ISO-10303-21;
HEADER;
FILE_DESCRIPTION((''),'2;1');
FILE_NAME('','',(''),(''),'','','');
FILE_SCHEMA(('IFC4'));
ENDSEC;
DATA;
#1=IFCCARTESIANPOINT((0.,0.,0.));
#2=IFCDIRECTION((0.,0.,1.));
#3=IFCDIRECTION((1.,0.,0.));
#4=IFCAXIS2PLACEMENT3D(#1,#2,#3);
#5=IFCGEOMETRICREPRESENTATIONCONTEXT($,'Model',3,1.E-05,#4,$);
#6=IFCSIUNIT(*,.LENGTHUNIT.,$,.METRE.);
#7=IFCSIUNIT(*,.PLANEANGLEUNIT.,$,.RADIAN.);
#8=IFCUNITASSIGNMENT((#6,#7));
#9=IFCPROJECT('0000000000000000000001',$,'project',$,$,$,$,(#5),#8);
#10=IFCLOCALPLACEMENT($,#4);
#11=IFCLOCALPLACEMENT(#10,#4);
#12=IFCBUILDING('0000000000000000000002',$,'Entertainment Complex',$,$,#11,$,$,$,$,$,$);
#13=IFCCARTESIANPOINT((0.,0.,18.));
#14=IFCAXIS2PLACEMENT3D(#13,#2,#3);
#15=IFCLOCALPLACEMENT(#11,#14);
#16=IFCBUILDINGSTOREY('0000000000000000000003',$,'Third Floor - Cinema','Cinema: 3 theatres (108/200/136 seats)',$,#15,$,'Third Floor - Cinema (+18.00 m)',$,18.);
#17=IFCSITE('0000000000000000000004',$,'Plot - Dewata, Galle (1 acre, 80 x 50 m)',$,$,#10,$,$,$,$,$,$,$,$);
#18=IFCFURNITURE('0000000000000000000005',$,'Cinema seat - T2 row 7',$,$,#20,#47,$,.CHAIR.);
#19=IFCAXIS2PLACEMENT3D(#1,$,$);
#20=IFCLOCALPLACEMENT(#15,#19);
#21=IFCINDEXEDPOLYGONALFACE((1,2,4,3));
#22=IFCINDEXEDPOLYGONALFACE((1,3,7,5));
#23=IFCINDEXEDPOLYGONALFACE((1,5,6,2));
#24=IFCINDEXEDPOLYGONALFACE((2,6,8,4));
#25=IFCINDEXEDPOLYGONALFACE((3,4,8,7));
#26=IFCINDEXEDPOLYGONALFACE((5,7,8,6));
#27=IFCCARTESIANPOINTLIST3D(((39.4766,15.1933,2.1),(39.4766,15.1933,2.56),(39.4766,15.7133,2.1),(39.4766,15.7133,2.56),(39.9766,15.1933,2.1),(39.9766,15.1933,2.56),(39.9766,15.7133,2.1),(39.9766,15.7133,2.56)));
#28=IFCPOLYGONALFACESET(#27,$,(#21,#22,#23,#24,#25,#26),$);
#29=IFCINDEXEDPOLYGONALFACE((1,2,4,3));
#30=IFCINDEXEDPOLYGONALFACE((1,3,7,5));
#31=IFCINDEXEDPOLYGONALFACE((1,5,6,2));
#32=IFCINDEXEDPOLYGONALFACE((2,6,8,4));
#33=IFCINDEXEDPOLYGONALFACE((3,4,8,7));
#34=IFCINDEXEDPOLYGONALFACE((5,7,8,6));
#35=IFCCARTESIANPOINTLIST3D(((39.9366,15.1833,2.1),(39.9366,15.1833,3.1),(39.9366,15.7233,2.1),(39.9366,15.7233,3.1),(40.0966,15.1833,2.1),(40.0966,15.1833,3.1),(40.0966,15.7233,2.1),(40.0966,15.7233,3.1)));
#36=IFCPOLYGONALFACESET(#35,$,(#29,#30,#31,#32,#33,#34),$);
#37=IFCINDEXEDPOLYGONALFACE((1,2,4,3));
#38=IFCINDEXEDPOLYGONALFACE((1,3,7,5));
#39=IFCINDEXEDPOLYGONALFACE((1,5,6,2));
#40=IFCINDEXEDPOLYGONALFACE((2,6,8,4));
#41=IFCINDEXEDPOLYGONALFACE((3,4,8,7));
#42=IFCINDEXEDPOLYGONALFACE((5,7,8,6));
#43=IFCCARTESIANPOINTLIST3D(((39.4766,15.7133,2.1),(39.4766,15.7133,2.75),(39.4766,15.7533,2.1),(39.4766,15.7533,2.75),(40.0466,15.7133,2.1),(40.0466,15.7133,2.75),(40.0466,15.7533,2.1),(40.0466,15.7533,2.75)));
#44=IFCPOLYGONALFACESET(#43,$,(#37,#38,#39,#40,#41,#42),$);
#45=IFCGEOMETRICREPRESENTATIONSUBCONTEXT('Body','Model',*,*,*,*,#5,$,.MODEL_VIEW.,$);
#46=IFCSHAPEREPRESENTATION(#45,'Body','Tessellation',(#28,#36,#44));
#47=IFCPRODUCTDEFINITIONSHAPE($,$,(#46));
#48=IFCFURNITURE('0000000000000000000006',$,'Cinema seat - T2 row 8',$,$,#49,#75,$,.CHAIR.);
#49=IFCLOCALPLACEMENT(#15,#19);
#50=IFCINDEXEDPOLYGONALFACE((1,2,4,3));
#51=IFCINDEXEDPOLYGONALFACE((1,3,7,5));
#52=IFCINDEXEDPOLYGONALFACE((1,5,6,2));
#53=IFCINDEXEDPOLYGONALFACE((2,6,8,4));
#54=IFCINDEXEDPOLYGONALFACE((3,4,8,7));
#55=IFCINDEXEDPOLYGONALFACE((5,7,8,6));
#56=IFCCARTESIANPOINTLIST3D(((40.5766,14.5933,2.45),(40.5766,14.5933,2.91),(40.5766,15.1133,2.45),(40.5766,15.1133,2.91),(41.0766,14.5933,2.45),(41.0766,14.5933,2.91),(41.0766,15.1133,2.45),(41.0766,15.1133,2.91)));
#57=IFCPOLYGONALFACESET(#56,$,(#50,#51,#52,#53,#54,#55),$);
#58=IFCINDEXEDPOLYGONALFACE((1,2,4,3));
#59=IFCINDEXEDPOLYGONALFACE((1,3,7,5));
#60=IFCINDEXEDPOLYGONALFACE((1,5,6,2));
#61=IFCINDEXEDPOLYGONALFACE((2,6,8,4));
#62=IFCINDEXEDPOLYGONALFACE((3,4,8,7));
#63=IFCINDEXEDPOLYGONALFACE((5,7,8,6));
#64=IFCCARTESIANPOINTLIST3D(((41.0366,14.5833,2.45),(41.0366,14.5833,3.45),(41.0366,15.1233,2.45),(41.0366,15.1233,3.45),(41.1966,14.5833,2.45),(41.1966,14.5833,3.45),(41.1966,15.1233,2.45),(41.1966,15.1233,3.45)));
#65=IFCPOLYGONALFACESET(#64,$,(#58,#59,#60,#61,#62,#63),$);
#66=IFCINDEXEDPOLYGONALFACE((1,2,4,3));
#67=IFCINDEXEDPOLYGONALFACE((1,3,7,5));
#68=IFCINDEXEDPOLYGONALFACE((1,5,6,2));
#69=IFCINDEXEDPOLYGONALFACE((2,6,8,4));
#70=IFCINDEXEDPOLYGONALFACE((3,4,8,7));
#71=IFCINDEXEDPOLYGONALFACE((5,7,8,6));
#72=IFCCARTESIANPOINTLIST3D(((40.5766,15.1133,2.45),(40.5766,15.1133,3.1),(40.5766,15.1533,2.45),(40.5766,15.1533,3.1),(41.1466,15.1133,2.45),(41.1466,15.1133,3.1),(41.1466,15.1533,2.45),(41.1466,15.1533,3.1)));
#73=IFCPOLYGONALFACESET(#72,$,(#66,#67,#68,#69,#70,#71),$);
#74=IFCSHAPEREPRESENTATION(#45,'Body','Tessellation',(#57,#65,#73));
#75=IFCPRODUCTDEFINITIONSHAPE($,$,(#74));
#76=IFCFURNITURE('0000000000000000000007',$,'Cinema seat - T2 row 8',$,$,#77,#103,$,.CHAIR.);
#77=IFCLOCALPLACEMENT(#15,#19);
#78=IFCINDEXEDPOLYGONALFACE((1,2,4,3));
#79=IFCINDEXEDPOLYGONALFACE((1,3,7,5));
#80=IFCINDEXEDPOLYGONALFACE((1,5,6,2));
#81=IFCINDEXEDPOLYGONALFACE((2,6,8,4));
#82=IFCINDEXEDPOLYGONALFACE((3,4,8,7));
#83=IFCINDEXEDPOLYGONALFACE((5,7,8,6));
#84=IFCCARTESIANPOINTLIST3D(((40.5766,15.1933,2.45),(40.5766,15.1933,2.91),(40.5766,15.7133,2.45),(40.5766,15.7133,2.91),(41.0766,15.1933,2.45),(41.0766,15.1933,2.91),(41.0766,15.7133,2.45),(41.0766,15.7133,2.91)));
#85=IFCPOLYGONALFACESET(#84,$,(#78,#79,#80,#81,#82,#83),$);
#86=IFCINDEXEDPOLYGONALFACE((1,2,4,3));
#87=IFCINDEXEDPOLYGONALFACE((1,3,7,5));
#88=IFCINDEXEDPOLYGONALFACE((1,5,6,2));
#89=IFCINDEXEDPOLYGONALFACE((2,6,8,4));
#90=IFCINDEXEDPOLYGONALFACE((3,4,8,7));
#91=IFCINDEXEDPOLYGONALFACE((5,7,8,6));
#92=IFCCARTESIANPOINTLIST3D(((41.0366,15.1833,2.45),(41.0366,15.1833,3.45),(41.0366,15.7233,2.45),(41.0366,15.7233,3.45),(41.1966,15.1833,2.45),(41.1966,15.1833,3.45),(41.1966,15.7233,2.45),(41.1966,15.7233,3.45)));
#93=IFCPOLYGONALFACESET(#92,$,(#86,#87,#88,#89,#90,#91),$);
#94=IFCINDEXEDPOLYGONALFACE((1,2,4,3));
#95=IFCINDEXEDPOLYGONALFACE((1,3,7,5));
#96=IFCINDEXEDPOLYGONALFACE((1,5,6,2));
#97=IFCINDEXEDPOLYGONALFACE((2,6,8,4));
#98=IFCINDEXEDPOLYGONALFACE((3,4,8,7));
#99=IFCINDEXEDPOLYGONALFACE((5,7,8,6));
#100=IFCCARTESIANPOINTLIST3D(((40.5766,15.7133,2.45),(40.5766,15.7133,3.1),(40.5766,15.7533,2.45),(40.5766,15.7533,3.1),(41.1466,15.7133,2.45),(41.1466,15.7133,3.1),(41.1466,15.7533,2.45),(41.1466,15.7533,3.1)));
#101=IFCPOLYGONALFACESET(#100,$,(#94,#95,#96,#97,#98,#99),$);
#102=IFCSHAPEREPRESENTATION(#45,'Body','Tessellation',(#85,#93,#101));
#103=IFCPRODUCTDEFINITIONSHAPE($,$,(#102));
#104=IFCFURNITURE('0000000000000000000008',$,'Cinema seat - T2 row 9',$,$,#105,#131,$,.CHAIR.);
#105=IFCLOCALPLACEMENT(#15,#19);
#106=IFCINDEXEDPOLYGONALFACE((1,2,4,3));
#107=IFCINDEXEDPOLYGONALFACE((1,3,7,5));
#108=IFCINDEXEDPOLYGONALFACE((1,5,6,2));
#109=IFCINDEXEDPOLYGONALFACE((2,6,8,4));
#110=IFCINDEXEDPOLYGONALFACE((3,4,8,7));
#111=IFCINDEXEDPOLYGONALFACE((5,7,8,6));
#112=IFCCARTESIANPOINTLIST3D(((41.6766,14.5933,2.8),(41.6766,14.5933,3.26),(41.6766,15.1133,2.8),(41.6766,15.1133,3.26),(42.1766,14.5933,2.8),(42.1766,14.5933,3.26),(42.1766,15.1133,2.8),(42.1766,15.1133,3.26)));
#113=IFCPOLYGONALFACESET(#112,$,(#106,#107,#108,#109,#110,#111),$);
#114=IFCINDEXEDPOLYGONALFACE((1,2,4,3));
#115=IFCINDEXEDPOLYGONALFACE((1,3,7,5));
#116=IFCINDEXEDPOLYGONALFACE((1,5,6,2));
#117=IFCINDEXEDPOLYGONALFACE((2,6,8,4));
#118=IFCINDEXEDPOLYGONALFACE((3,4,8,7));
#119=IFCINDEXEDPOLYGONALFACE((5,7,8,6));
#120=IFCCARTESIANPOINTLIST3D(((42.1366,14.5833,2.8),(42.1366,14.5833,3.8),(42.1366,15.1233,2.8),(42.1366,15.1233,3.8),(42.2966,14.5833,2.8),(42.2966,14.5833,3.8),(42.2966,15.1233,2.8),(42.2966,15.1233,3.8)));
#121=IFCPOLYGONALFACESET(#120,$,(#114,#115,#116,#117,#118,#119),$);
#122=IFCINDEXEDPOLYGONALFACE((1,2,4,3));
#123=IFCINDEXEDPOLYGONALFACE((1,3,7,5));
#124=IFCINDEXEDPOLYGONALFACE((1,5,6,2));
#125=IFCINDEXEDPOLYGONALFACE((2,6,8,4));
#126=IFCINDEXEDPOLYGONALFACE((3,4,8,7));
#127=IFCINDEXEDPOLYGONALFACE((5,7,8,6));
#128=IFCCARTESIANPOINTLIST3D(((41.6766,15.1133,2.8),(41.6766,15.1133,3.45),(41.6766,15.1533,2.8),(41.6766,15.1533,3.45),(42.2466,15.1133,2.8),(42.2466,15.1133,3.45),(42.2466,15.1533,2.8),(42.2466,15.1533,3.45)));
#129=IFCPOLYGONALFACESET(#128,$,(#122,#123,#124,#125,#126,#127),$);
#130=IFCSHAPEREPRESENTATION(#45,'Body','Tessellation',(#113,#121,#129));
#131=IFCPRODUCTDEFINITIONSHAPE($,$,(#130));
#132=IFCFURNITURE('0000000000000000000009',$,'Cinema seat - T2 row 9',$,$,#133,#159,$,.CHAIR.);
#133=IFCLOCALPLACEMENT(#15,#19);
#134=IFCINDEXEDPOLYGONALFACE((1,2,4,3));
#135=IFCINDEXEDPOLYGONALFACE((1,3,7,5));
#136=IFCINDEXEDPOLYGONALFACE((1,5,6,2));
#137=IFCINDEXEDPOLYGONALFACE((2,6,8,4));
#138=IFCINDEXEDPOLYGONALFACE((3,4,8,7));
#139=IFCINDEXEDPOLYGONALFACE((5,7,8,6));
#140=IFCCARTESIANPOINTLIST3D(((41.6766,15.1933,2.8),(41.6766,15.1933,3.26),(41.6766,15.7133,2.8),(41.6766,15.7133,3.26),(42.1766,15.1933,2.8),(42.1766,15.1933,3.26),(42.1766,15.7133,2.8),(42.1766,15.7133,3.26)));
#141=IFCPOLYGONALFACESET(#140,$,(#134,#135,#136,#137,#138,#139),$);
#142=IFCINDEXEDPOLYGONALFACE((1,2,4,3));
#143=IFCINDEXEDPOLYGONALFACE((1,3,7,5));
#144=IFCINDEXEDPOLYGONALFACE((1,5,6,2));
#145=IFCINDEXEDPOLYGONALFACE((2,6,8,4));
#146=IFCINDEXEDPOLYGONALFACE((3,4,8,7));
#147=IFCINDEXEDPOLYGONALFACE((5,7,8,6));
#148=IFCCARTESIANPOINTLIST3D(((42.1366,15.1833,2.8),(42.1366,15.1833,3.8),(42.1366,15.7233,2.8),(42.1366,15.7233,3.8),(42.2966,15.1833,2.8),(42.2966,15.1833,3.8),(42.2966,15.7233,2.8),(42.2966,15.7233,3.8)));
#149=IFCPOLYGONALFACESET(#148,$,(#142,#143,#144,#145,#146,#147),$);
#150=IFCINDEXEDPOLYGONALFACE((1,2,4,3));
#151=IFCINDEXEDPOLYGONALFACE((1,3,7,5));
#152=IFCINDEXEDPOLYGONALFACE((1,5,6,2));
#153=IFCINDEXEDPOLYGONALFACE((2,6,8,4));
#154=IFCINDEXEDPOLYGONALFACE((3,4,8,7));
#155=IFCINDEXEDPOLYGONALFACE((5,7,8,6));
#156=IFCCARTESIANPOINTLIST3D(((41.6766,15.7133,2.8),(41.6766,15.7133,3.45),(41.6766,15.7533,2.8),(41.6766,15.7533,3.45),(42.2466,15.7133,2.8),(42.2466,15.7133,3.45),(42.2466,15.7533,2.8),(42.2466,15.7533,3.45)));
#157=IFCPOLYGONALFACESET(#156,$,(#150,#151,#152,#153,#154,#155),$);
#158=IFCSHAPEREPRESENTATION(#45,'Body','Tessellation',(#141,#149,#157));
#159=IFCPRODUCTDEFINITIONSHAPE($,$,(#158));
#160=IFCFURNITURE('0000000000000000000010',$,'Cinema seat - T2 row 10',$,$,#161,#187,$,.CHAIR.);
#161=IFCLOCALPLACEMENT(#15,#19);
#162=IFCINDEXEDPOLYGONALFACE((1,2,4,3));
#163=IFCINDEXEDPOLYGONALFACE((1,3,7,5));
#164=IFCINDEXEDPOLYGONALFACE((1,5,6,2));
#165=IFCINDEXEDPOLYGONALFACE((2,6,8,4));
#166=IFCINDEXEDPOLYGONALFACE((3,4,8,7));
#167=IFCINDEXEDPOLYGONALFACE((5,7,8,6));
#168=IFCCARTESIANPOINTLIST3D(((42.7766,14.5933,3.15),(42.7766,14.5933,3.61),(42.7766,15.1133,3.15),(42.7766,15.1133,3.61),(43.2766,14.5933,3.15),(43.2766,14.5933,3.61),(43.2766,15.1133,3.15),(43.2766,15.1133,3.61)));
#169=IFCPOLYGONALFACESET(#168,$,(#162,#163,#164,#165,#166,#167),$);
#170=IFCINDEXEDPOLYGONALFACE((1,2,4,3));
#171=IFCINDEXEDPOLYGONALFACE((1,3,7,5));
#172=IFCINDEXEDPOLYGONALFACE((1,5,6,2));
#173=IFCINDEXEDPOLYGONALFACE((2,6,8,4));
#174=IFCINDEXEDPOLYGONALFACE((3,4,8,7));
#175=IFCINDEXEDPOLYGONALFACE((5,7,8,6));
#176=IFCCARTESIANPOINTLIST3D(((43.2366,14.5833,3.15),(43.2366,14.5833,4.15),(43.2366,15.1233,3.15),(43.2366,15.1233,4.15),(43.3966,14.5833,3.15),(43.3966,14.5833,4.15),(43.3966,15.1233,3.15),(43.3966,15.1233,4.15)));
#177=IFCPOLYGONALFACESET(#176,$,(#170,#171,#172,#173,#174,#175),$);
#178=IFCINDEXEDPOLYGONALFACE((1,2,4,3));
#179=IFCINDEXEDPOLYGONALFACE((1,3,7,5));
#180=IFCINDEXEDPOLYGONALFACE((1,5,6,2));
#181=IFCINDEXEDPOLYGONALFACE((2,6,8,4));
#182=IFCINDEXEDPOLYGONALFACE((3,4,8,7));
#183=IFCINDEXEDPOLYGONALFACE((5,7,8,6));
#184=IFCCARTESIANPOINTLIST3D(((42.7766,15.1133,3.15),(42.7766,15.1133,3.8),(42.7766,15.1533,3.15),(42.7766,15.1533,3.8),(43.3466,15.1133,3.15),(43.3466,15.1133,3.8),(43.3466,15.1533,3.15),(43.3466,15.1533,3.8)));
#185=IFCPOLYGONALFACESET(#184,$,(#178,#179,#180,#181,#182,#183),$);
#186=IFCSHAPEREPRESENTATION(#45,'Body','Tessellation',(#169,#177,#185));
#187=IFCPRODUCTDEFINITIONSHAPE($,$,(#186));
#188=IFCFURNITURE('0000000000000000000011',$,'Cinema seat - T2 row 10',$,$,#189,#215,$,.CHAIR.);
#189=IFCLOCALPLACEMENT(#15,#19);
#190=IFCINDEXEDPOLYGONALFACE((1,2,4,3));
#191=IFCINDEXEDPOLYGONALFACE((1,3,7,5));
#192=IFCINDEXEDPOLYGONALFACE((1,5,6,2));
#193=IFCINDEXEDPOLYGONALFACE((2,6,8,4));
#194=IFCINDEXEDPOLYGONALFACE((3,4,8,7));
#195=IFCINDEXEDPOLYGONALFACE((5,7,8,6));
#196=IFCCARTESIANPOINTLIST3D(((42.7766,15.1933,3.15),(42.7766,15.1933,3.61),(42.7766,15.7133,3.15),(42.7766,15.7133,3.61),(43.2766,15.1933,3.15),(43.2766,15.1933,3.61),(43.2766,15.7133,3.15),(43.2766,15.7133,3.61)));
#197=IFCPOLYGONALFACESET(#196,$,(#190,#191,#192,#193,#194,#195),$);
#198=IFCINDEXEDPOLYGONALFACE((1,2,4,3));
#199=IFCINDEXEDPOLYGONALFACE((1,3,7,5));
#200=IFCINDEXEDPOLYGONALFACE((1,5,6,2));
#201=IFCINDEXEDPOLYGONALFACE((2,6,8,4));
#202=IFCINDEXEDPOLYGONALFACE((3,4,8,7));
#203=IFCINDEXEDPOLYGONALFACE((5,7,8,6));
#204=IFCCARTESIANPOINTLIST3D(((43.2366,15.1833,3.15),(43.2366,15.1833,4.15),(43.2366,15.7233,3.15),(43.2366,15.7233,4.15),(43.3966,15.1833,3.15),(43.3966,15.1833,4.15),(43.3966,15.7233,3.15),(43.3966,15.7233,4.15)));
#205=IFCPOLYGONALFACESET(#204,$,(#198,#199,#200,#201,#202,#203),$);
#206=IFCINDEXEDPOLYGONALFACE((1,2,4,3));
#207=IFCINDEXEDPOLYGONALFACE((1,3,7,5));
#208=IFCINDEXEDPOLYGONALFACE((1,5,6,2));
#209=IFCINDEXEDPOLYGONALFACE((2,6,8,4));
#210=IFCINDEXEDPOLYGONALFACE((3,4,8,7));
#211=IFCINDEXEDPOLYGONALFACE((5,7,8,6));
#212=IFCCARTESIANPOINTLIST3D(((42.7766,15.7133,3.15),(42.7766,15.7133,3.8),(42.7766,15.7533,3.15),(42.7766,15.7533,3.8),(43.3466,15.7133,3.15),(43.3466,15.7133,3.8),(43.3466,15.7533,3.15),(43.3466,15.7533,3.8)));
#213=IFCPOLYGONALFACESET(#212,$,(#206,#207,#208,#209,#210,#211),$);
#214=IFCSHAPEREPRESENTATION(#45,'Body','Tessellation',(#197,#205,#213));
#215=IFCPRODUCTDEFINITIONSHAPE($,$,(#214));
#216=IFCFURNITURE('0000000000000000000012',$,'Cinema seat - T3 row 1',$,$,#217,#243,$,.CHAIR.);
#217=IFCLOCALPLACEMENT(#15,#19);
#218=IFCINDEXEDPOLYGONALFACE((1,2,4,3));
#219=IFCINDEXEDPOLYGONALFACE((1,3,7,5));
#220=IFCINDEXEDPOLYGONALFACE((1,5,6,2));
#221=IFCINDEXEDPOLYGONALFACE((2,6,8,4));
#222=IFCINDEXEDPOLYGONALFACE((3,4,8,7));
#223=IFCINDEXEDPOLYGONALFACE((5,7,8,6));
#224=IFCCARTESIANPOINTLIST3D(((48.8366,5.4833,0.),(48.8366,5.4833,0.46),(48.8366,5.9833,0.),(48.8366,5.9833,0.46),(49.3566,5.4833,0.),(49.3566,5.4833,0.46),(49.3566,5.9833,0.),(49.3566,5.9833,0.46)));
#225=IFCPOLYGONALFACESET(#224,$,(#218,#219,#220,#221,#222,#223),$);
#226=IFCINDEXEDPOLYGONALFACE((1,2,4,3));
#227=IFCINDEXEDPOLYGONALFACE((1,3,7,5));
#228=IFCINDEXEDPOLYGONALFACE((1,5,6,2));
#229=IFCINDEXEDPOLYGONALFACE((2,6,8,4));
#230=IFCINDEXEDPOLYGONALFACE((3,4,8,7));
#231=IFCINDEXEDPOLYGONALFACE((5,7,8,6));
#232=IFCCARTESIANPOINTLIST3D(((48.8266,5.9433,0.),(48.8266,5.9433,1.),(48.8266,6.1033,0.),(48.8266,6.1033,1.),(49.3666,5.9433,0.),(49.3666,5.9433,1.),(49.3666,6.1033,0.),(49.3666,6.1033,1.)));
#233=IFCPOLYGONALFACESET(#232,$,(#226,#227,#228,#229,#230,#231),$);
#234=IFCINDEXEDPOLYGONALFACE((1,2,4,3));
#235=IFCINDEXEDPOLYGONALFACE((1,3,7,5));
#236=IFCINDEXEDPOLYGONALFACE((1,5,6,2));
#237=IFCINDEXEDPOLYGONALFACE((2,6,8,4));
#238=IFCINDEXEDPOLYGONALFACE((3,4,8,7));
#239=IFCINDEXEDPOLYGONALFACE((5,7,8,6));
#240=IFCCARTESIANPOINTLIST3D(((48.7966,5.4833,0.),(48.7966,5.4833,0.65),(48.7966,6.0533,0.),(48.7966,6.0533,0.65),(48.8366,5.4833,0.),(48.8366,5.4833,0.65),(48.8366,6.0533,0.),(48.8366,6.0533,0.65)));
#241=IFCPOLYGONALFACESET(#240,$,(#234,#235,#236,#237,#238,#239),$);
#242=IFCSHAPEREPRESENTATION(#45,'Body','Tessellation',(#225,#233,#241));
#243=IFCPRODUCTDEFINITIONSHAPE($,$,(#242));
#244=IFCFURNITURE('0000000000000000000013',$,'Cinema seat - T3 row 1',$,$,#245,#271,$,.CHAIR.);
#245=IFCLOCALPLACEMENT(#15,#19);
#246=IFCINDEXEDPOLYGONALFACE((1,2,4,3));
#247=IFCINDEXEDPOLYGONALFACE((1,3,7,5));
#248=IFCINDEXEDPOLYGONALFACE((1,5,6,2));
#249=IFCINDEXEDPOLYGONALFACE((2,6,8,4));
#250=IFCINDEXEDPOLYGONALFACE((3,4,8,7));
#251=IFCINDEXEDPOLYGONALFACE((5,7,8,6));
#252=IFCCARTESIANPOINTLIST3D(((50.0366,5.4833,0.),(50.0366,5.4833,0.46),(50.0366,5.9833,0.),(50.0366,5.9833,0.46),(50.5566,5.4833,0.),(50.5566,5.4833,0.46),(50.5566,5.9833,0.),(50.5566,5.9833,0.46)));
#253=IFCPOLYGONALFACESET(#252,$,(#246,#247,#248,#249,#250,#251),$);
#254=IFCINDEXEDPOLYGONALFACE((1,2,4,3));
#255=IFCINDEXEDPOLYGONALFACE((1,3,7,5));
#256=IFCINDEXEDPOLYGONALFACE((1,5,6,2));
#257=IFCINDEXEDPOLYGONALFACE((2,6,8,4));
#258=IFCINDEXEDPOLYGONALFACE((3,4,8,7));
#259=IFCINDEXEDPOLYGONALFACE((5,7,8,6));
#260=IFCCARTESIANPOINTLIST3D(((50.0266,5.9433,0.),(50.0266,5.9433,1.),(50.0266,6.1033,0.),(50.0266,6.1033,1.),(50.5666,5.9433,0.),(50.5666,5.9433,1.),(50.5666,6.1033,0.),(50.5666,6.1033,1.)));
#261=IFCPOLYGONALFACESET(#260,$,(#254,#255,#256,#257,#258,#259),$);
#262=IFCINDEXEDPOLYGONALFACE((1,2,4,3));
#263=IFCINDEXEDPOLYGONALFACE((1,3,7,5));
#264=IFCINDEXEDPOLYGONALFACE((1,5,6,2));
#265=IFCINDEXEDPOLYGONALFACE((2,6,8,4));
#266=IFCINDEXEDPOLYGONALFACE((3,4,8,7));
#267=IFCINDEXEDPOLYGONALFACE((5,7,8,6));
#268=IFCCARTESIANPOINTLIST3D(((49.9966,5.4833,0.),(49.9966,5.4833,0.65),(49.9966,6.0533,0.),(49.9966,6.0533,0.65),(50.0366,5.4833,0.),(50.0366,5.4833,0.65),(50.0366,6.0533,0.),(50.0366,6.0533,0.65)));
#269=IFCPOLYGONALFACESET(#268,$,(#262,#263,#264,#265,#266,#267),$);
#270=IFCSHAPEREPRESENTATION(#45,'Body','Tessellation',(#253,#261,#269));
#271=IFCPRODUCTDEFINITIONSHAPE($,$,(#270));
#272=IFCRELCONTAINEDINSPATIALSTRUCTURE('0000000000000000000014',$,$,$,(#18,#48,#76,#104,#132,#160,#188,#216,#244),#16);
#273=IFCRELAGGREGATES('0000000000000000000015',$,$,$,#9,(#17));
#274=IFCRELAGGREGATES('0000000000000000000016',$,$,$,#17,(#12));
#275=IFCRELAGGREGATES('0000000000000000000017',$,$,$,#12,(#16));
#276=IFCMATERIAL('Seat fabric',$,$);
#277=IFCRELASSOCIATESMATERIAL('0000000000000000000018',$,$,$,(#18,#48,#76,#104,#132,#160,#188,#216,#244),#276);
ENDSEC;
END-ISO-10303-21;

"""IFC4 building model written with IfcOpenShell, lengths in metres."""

from ifc_helpers import new_model, si_unit, frame, origin_with_axes, place, context, subcontext, project, spatial, polyline, outline, extrude, material, element, save


model = new_model("IFC4")

# Units and contexts
model_context = context("Model", 3, precision=1e-05, world=origin_with_axes())
body_context = subcontext(model_context, "Body", "Model", "MODEL_VIEW")
ifc_project = project(units=[si_unit("LENGTHUNIT", "METRE"), si_unit("PLANEANGLEUNIT", "RADIAN")], contexts=[model_context])

# Site, building, storey
site_placement = place(None, origin_with_axes())
site = spatial("IfcSite", under=ifc_project, at=site_placement, Name="Plot - Dewata, Galle (1 acre, 80 x 50 m)")
building_placement = place(site_placement, origin_with_axes())
building = spatial("IfcBuilding", under=site, at=building_placement, Name="Entertainment Complex")
storey_placement = place(building_placement, frame((0.0, 0.0, 18.0), z_axis=(0.0, 0.0, 1.0), x_axis=(1.0, 0.0, 0.0)))
storey = spatial("IfcBuildingStorey", under=building, at=storey_placement, Name="Third Floor - Cinema", Description="Cinema: 3 theatres (108/200/136 seats)", LongName="Third Floor - Cinema (+18.00 m)", Elevation=18.0)

# Furniture
ifc_material_1 = material(Name="Seat fabric")
for number, where, z_axis, x_axis, name in (
    (1, (40.0966, 15.4533, 2.1), (0.0, 0.0, 1.0), (1.0, 0.0, 0.0), "Cinema seat - T2 row 7"),
    (2, (41.1966, 14.8533, 2.45), (0.0, 0.0, 1.0), (1.0, 0.0, 0.0), "Cinema seat - T2 row 8"),
    (3, (41.1966, 15.4533, 2.45), (0.0, 0.0, 1.0), (1.0, 0.0, 0.0), "Cinema seat - T2 row 8"),
    (4, (42.2966, 14.8533, 2.8), (0.0, 0.0, 1.0), (1.0, 0.0, 0.0), "Cinema seat - T2 row 9"),
    (5, (42.2966, 15.4533, 2.8), (0.0, 0.0, 1.0), (1.0, 0.0, 0.0), "Cinema seat - T2 row 9"),
    (6, (43.3966, 14.8533, 3.15), (0.0, 0.0, 1.0), (1.0, 0.0, 0.0), "Cinema seat - T2 row 10"),
    (7, (43.3966, 15.4533, 3.15), (0.0, 0.0, 1.0), (1.0, 0.0, 0.0), "Cinema seat - T2 row 10"),
    (8, (49.0966, 6.1033, 0.0), (0.0, 0.0, 1.0), (0.0, 1.0, 0.0), "Cinema seat - T3 row 1"),
    (9, (50.2966, 6.1033, 0.0), (0.0, 0.0, 1.0), (0.0, 1.0, 0.0), "Cinema seat - T3 row 1"),
):
    element("IfcFurniture", number, at=place(storey_placement, frame(where, z_axis=z_axis, x_axis=x_axis)), inside=storey, material=ifc_material_1, Name=name, PredefinedType="CHAIR", context=body_context, shape_type="SweptSolid", body=[
        extrude(outline(polyline([(-0.62, -0.26), (-0.12, -0.26), (-0.12, 0.26), (-0.62, 0.26), (-0.62, -0.26)])), origin_with_axes(), (0.0, 0.0, 1.0), 0.46),
        extrude(outline(polyline([(-0.16, -0.27), (0.0, -0.27), (0.0, 0.27), (-0.16, 0.27), (-0.16, -0.27)])), origin_with_axes(), (0.0, 0.0, 1.0), 1.0),
        extrude(outline(polyline([(-0.62, 0.26), (-0.05, 0.26), (-0.05, 0.3), (-0.62, 0.3), (-0.62, 0.26)])), origin_with_axes(), (0.0, 0.0, 1.0), 0.65),
    ])

save(model, "model.ifc")
